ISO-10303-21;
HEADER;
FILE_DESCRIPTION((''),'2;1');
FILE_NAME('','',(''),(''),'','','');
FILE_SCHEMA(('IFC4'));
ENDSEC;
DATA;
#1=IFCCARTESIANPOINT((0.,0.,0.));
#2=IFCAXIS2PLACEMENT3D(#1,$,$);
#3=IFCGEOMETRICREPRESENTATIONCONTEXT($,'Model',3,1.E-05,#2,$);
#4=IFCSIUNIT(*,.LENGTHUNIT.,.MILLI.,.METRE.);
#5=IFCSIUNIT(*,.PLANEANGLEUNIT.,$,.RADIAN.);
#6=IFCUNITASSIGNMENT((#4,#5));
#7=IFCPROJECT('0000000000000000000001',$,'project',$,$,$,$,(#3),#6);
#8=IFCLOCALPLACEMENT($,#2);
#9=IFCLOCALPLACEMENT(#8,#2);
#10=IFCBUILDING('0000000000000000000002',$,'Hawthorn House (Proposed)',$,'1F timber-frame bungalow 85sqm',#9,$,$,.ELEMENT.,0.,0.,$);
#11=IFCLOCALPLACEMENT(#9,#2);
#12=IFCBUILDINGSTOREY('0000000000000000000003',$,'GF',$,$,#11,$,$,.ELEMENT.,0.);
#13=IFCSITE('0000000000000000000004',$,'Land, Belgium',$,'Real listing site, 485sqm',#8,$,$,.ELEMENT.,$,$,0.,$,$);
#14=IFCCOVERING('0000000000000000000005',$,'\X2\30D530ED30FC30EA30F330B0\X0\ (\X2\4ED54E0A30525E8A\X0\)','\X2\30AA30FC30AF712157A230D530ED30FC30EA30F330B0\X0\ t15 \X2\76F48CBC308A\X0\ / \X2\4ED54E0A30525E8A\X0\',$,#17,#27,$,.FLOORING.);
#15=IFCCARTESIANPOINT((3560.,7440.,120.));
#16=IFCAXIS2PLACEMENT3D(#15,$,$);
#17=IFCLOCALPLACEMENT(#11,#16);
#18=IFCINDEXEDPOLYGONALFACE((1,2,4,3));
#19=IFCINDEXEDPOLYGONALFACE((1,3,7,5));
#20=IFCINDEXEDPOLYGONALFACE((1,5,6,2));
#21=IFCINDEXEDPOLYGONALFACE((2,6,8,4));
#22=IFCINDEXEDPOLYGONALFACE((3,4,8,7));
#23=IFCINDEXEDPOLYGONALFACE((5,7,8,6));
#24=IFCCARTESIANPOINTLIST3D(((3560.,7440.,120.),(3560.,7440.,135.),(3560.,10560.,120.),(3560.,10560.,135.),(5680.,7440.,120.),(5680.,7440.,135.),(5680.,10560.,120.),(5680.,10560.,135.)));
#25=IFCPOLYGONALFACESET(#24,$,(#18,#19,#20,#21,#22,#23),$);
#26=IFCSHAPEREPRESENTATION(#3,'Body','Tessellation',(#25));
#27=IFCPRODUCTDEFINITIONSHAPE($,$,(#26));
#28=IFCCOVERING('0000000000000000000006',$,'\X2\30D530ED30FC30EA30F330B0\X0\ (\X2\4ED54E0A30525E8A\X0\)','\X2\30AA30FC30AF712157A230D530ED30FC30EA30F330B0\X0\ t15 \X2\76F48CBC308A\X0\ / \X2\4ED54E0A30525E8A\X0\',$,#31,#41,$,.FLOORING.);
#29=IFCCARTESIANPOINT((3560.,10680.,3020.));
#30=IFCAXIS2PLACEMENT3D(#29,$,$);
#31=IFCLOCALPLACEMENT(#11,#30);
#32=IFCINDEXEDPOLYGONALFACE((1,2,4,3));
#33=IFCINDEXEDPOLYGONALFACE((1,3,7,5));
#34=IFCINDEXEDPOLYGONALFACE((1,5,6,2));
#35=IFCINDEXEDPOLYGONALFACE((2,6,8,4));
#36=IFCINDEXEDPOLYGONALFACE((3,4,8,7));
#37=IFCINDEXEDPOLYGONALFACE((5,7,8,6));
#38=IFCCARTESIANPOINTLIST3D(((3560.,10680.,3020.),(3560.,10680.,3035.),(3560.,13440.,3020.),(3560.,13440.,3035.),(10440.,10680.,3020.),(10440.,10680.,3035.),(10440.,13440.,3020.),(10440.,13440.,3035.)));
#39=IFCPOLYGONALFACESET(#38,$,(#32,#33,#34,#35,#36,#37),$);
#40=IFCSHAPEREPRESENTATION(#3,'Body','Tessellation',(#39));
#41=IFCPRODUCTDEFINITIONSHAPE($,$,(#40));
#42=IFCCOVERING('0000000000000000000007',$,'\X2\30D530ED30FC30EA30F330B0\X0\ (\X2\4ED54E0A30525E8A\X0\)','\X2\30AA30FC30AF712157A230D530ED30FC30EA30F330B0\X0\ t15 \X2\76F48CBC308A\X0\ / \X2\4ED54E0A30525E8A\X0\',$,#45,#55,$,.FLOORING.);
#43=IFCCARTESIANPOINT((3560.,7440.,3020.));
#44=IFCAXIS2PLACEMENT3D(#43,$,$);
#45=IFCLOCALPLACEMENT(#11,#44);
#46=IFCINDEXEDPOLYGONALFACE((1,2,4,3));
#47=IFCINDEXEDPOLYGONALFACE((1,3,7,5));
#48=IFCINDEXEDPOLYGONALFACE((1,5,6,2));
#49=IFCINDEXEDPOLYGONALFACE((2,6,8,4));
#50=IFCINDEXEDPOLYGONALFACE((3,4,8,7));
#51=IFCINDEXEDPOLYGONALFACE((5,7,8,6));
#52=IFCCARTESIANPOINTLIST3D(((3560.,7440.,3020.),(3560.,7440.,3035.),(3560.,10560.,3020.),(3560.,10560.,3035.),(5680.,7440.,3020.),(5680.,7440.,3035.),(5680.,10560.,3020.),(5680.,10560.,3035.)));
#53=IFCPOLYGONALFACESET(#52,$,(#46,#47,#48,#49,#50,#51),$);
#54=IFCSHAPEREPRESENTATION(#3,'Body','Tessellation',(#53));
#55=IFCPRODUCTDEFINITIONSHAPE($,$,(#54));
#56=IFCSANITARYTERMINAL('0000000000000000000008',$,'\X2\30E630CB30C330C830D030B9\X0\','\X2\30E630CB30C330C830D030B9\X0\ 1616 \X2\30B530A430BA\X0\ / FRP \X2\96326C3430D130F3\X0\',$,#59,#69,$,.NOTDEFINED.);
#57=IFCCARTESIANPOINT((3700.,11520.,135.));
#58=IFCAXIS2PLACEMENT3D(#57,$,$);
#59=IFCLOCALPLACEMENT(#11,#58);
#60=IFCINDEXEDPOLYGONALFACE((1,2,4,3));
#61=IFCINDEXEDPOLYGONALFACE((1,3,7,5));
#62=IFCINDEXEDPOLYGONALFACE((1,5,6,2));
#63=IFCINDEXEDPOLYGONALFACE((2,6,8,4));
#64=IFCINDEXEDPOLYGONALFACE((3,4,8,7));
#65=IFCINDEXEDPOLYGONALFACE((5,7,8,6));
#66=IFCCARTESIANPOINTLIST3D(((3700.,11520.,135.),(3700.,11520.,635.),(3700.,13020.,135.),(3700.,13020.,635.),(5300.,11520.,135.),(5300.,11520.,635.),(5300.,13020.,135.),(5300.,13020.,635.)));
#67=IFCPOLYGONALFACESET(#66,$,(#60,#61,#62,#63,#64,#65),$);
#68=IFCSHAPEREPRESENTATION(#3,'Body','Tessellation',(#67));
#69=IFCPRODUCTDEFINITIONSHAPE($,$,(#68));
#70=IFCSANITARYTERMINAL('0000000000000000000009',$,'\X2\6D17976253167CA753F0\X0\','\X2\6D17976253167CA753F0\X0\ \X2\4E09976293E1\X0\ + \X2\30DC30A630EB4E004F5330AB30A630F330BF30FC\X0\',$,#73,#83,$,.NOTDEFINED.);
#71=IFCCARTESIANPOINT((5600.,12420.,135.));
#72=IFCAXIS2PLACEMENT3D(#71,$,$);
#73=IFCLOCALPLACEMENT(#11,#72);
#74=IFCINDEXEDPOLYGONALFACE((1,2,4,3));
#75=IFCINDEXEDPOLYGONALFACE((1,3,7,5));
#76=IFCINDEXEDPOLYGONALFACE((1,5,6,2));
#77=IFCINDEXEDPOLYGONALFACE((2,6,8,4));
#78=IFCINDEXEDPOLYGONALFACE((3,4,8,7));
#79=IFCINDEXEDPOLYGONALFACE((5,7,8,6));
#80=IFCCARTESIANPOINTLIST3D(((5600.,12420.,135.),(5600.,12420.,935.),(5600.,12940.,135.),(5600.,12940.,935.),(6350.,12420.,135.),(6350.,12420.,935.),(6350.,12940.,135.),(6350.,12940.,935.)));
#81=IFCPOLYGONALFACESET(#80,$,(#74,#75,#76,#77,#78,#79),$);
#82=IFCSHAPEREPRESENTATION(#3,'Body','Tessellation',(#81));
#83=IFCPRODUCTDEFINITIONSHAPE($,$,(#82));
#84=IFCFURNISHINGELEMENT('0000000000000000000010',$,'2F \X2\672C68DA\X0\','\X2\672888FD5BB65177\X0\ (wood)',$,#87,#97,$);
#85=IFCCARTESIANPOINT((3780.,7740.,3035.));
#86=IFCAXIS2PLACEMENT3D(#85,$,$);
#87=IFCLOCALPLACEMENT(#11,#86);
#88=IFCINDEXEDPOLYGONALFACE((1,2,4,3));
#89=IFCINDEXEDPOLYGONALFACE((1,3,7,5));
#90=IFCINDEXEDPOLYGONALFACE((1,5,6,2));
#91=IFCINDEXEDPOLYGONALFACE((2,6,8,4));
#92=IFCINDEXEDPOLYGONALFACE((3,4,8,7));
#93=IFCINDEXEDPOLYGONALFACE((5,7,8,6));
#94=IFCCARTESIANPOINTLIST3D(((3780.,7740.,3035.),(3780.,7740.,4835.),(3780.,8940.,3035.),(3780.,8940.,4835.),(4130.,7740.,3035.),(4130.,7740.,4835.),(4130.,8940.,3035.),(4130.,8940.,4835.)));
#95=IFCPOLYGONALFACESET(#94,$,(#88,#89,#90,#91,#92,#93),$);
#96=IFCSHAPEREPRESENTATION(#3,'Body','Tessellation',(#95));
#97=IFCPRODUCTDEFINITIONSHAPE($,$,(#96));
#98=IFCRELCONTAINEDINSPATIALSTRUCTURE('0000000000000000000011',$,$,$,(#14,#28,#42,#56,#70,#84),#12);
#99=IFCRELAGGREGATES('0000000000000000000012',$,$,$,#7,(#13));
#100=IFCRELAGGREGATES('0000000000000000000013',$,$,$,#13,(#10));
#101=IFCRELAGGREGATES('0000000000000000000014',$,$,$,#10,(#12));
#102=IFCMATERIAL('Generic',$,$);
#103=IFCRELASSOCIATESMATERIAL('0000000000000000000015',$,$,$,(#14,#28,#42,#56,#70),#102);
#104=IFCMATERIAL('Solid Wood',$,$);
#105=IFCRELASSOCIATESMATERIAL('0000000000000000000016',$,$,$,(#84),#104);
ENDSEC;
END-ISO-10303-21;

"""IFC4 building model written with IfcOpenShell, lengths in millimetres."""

from ifc_helpers import new_model, si_unit, frame, frame_2d, origin, place, context, project, spatial, rectangle, extrude, material, element, save


model = new_model("IFC4")

# Units and contexts
model_context = context("Model", 3, precision=1e-05, world=origin())
ifc_project = project(units=[si_unit("LENGTHUNIT", "METRE", prefix="MILLI"), si_unit("PLANEANGLEUNIT", "RADIAN")], contexts=[model_context])

# Site, building, storey
site_placement = place(None, origin())
site = spatial("IfcSite", under=ifc_project, at=site_placement, Name="Land, Belgium", ObjectType="Real listing site, 485sqm", CompositionType="ELEMENT", RefElevation=0.0)
building_placement = place(site_placement, origin())
building = spatial("IfcBuilding", under=site, at=building_placement, Name="Hawthorn House (Proposed)", ObjectType="1F timber-frame bungalow 85sqm", CompositionType="ELEMENT", ElevationOfRefHeight=0.0, ElevationOfTerrain=0.0)
storey_placement = place(building_placement, origin())
storey = spatial("IfcBuildingStorey", under=building, at=storey_placement, Name="GF", CompositionType="ELEMENT", Elevation=0.0)

# Shared definitions
ifc_material_1 = material(Name="Solid Wood")

# Coverings
ifc_material_2 = material(Name="Generic")
covering_1_placement = place(storey_placement, frame((3560.0, 7440.0, 120.0)))
element("IfcCovering", 1, at=covering_1_placement, inside=storey, material=ifc_material_2, Name="フローリング (仕上げ床)", Description="オーク無垢フローリング t15 直貼り / 仕上げ床", PredefinedType="FLOORING", context=model_context, shape_type="SweptSolid", body=[
    extrude(rectangle(XDim=2120.0, YDim=3120.0, at=frame_2d((1060.0, 1560.0))), frame((3560.0, 7440.0, 120.0)), (0.0, 0.0, 1.0), 15.0),
])
covering_2_placement = place(storey_placement, frame((3560.0, 10680.0, 3020.0)))
element("IfcCovering", 2, at=covering_2_placement, inside=storey, material=ifc_material_2, Name="フローリング (仕上げ床)", Description="オーク無垢フローリング t15 直貼り / 仕上げ床", PredefinedType="FLOORING", context=model_context, shape_type="SweptSolid", body=[
    extrude(rectangle(XDim=6880.0, YDim=2760.0, at=frame_2d((3440.0, 1380.0))), frame((3560.0, 10680.0, 3020.0)), (0.0, 0.0, 1.0), 15.0),
])
covering_3_placement = place(storey_placement, frame((3560.0, 7440.0, 3020.0)))
element("IfcCovering", 3, at=covering_3_placement, inside=storey, material=ifc_material_2, Name="フローリング (仕上げ床)", Description="オーク無垢フローリング t15 直貼り / 仕上げ床", PredefinedType="FLOORING", context=model_context, shape_type="SweptSolid", body=[
    extrude(rectangle(XDim=2120.0, YDim=3120.0, at=frame_2d((1060.0, 1560.0))), frame((3560.0, 7440.0, 3020.0)), (0.0, 0.0, 1.0), 15.0),
])

# Sanitary terminals
sanitary_terminal_1_placement = place(storey_placement, frame((3700.0, 11520.0, 135.0)))
element("IfcSanitaryTerminal", 4, at=sanitary_terminal_1_placement, inside=storey, material=ifc_material_2, Name="ユニットバス", Description="ユニットバス 1616 サイズ / FRP 防水パン", PredefinedType="NOTDEFINED", context=model_context, shape_type="SweptSolid", body=[
    extrude(rectangle(XDim=1600.0, YDim=1500.0, at=frame_2d((800.0, 750.0))), frame((3700.0, 11520.0, 135.0)), (0.0, 0.0, 1.0), 500.0),
])
sanitary_terminal_2_placement = place(storey_placement, frame((5600.0, 12420.0, 135.0)))
element("IfcSanitaryTerminal", 5, at=sanitary_terminal_2_placement, inside=storey, material=ifc_material_2, Name="洗面化粧台", Description="洗面化粧台 三面鏡 + ボウル一体カウンター", PredefinedType="NOTDEFINED", context=model_context, shape_type="SweptSolid", body=[
    extrude(rectangle(XDim=750.0, YDim=520.0, at=frame_2d((375.0, 260.0))), frame((5600.0, 12420.0, 135.0)), (0.0, 0.0, 1.0), 800.0),
])

# Furnishing element
furnishing_placement = place(storey_placement, frame((3780.0, 7740.0, 3035.0)))
element("IfcFurnishingElement", 6, at=furnishing_placement, inside=storey, material=ifc_material_1, Name="2F 本棚", Description="木製家具 (wood)", context=model_context, shape_type="SweptSolid", body=[
    extrude(rectangle(XDim=350.0, YDim=1200.0, at=frame_2d((175.0, 600.0))), frame((3780.0, 7740.0, 3035.0)), (0.0, 0.0, 1.0), 1800.0),
])

save(model, "model.ifc")
